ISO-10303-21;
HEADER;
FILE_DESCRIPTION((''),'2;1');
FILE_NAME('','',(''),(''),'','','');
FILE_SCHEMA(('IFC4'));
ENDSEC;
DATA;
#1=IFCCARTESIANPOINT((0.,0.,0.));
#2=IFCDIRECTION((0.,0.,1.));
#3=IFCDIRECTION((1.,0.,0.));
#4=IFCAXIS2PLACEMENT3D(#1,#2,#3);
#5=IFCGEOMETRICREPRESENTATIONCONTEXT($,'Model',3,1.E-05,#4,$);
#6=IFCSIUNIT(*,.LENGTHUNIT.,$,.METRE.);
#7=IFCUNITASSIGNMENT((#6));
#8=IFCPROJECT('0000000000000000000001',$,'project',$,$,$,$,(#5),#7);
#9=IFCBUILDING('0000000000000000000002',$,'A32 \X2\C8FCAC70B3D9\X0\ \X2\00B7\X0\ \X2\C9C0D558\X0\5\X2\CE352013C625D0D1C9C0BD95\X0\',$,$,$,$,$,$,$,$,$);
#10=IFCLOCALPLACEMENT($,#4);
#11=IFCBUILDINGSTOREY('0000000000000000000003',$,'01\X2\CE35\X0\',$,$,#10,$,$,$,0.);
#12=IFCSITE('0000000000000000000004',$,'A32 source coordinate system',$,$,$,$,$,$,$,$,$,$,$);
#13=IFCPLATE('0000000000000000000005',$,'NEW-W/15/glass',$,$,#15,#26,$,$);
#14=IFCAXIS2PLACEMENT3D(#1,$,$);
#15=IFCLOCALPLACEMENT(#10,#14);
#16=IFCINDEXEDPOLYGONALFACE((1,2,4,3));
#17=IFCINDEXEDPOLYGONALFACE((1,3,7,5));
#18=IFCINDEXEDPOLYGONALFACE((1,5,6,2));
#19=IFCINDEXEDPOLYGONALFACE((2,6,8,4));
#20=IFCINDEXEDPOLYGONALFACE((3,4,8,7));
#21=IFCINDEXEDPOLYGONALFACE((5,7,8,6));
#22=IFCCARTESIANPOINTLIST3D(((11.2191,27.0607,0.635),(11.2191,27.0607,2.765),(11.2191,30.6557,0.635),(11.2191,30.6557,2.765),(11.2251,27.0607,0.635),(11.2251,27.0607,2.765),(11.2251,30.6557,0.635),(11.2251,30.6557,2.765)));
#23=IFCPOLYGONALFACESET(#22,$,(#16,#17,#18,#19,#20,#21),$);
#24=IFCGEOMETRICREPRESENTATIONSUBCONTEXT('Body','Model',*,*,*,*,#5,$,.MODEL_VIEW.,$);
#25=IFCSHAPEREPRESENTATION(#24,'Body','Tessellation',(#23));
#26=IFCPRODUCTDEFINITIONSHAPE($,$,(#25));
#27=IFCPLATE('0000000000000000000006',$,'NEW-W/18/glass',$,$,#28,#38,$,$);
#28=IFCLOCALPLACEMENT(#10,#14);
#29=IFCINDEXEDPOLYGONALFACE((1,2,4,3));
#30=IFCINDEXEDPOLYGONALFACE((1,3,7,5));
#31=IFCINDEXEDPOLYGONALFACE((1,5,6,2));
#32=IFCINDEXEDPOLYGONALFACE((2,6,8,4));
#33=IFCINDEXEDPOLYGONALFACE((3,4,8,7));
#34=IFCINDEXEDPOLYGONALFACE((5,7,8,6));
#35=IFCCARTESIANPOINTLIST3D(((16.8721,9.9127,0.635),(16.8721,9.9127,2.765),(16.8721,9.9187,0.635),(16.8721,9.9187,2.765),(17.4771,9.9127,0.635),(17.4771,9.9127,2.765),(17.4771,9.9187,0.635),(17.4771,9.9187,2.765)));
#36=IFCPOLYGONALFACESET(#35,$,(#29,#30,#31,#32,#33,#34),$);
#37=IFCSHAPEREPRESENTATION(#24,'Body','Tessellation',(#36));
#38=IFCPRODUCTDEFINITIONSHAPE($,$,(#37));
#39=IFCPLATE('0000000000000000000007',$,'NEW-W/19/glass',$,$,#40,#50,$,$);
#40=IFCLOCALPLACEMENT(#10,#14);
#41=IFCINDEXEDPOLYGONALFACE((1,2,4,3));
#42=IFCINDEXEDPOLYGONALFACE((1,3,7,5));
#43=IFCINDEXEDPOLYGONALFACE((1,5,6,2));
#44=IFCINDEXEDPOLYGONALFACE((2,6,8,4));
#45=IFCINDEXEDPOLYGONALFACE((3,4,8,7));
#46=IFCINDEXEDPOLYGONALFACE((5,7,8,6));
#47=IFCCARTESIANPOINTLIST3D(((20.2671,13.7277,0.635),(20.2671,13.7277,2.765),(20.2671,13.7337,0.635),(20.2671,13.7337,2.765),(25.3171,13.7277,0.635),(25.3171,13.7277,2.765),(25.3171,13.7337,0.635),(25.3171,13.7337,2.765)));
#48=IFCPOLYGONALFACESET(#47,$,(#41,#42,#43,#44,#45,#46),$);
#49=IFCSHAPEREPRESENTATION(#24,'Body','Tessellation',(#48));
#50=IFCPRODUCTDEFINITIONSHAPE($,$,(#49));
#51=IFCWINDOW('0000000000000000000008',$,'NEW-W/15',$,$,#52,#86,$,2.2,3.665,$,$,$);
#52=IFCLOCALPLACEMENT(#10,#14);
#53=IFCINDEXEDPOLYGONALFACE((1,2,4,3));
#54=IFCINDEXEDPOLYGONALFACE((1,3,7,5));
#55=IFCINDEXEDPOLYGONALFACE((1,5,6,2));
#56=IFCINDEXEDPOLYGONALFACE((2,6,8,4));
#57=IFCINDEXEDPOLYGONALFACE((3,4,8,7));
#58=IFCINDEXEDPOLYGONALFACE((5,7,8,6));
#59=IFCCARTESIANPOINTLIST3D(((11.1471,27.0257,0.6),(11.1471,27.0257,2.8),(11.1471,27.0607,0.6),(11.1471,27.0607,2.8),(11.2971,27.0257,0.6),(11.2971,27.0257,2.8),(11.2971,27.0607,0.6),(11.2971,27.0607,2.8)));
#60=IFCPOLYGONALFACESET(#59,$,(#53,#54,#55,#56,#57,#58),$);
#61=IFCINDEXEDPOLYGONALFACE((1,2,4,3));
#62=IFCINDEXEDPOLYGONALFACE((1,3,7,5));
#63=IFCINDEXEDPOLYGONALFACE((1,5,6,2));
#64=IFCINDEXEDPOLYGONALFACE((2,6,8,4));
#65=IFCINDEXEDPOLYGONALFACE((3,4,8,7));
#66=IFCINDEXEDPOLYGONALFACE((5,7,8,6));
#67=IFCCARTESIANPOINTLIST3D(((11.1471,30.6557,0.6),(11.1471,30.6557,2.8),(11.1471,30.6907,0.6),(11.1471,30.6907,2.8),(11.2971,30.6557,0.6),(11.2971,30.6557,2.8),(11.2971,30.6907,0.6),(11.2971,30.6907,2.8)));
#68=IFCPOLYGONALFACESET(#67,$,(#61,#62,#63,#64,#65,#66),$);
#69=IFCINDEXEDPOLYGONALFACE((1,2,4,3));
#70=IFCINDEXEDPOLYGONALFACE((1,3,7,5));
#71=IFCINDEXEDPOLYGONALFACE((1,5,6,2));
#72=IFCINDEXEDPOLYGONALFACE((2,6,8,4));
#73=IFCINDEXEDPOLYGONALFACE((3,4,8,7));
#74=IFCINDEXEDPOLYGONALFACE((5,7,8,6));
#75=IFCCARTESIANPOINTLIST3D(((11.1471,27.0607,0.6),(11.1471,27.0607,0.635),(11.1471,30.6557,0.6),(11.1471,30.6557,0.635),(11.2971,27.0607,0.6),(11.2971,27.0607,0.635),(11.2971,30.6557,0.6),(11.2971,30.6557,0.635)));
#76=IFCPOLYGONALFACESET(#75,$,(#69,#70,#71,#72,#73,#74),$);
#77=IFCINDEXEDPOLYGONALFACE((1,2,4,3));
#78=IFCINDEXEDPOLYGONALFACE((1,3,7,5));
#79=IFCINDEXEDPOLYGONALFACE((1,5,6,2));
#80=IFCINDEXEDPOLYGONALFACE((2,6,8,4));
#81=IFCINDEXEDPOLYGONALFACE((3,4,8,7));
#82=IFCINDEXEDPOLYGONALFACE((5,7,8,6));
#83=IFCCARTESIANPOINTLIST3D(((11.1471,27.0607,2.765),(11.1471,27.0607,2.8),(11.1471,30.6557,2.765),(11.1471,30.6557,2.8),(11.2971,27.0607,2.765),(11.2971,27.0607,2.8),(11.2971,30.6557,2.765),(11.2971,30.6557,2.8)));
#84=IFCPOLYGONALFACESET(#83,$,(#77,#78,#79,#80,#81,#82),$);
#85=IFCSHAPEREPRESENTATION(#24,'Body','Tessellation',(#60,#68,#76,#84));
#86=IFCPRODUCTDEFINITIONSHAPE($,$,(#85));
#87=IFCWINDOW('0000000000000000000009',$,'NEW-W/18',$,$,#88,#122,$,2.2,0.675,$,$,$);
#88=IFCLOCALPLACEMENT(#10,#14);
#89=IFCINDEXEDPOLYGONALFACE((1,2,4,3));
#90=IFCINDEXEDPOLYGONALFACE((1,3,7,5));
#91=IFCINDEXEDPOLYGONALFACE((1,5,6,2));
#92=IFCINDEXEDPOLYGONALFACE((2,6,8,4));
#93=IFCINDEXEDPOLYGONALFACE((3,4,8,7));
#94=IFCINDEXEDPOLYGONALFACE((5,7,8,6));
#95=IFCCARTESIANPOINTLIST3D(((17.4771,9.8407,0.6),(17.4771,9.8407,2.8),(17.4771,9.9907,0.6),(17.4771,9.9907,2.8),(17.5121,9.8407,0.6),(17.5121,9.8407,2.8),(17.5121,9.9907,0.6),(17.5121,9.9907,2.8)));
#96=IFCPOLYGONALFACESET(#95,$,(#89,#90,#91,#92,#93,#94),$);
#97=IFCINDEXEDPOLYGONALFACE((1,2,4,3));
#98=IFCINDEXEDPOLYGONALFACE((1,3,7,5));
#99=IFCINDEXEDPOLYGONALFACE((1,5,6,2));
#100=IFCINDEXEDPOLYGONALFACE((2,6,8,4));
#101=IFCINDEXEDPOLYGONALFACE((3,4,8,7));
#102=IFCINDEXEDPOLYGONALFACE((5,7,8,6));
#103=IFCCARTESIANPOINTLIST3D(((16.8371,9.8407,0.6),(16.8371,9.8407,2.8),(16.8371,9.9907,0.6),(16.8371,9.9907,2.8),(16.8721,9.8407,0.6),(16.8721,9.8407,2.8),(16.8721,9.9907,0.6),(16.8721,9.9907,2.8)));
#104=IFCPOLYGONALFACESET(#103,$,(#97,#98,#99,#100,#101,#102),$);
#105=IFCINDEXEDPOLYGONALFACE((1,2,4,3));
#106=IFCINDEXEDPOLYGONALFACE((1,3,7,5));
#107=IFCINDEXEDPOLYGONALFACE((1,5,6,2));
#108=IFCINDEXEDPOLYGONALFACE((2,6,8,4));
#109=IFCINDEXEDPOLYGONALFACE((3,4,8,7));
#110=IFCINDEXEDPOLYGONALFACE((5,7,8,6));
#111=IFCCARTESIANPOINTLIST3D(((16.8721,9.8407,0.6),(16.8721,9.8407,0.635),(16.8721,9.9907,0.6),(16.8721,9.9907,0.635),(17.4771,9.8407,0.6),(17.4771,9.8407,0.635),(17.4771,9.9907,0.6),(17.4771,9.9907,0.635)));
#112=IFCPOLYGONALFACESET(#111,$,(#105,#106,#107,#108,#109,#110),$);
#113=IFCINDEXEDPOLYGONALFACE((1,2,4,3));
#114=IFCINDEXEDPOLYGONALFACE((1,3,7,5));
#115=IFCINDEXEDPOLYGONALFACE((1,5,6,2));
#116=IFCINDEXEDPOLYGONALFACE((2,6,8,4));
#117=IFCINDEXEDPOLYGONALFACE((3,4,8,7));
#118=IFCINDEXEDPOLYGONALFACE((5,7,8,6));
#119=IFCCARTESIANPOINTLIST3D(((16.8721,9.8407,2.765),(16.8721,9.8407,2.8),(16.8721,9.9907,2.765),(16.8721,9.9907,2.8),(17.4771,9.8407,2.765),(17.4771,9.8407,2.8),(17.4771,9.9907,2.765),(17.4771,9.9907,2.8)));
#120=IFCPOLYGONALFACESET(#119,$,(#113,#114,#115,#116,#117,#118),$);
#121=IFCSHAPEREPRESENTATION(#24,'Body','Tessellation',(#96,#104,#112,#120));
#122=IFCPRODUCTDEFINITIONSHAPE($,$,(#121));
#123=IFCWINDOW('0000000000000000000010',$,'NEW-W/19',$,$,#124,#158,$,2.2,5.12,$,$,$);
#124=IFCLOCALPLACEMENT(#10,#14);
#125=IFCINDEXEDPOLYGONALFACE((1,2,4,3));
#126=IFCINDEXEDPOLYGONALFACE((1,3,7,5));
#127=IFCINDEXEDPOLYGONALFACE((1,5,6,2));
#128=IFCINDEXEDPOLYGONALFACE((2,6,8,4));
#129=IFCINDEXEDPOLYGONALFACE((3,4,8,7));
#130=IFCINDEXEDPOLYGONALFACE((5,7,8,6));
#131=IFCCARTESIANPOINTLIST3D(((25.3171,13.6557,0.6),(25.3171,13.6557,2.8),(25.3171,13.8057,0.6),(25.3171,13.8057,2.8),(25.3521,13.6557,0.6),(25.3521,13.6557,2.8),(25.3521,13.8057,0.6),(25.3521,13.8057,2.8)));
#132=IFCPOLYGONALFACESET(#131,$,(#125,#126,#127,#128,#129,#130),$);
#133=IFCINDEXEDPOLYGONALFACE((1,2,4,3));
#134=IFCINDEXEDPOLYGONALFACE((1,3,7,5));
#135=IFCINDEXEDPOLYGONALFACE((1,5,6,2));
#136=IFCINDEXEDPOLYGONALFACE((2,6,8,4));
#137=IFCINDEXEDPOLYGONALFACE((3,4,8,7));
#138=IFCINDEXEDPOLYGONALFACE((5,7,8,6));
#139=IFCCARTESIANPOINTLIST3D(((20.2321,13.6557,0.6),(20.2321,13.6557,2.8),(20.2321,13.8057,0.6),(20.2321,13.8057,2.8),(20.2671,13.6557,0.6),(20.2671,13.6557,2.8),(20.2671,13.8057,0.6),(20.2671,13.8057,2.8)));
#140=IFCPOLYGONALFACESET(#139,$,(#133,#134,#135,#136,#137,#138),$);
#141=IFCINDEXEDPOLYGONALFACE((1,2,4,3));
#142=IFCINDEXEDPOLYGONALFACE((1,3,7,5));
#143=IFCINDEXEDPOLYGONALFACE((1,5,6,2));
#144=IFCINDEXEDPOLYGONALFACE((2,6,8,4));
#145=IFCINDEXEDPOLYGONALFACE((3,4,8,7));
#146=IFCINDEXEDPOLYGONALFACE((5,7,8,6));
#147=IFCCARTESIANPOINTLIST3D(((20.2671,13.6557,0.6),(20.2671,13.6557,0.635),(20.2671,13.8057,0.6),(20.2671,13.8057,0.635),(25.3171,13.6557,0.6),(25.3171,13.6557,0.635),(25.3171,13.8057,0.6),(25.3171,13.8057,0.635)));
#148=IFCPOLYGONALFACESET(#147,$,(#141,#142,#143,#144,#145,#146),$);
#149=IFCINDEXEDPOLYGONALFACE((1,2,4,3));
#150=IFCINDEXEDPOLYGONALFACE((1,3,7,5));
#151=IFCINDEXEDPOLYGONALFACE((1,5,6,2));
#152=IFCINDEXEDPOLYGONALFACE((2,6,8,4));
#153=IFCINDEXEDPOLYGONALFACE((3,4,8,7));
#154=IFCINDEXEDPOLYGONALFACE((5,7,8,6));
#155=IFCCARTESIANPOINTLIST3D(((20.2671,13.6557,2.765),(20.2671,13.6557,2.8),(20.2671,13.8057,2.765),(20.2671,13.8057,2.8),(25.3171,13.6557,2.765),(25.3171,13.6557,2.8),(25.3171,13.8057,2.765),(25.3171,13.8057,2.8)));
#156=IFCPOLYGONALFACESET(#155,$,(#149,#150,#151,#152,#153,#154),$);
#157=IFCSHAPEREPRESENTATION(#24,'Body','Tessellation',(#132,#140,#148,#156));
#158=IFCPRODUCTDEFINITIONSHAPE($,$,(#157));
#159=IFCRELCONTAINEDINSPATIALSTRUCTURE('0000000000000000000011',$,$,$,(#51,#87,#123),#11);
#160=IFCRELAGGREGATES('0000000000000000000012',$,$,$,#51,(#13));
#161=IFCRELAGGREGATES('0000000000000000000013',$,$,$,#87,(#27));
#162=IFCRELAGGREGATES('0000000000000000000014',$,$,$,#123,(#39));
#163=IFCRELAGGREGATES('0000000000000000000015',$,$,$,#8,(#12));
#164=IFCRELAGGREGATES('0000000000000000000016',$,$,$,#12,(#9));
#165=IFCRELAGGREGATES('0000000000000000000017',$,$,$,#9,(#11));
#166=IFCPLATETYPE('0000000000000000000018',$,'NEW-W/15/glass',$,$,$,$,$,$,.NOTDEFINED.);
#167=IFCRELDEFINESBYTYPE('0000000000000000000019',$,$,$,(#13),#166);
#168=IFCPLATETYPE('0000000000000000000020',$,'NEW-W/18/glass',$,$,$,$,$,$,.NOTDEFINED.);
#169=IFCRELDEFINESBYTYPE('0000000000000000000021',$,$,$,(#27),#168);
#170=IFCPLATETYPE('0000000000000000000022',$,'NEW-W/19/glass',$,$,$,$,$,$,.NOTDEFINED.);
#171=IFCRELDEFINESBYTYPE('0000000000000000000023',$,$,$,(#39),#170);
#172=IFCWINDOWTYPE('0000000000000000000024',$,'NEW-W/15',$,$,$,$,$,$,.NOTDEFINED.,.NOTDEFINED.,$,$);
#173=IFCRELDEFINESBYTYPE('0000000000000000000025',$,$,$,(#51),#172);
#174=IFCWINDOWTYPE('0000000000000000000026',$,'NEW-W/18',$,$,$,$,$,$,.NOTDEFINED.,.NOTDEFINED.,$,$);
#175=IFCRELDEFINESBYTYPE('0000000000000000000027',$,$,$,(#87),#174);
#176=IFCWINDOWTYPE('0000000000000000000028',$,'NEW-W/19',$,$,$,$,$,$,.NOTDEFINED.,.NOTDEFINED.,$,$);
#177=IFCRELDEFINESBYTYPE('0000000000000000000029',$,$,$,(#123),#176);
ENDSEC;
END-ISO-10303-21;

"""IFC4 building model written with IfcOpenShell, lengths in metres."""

from ifc_helpers import new_model, si_unit, frame, origin, origin_with_axes, place, context, subcontext, project, spatial, polyline, outline, extrude, source, transform, mapped, type_object, type_shapes, element, aggregate, save


model = new_model("IFC4")

# Units and contexts
model_context = context("Model", 3, precision=1e-05, world=origin_with_axes())
body_context = subcontext(model_context, "Body", "Model", "MODEL_VIEW")
ifc_project = project(units=[si_unit("LENGTHUNIT", "METRE")], contexts=[model_context])

# Plates
plate_type_1 = type_object("IfcPlateType", Name="NEW-W/15/glass", PredefinedType="NOTDEFINED")
shared_shape_1 = source(origin(), body_context, "Body", "SweptSolid", [
    extrude(outline(polyline([(11.2251, 27.0607), (11.2191, 27.0607), (11.2191, 30.6557), (11.2251, 30.6557), (11.2251, 27.0607)])), frame((0.0, 0.0, 0.635)), (0.0, 0.0, 1.0), 2.13),
])
type_shapes(plate_type_1, [shared_shape_1])
storey_placement = place(None, origin_with_axes())
window_1_placement = place(storey_placement, origin_with_axes())
plate_1_placement = place(window_1_placement, origin_with_axes())
plate_1 = element("IfcPlate", 1, at=plate_1_placement, type_object=plate_type_1, Name="NEW-W/15/glass", context=body_context, shape_type="MappedRepresentation", body=[
    mapped(shared_shape_1, transform((0.0, 0.0, 0.0), scale=1.0)),
])
plate_type_2 = type_object("IfcPlateType", Name="NEW-W/18/glass", PredefinedType="NOTDEFINED")
shared_shape_2 = source(origin(), body_context, "Body", "SweptSolid", [
    extrude(outline(polyline([(17.4771, 9.9127), (16.8721, 9.9127), (16.8721, 9.9187), (17.4771, 9.9187), (17.4771, 9.9127)])), frame((0.0, 0.0, 0.635)), (0.0, 0.0, 1.0), 2.13),
])
type_shapes(plate_type_2, [shared_shape_2])
window_2_placement = place(storey_placement, origin_with_axes())
plate_2_placement = place(window_2_placement, origin_with_axes())
plate_2 = element("IfcPlate", 2, at=plate_2_placement, type_object=plate_type_2, Name="NEW-W/18/glass", context=body_context, shape_type="MappedRepresentation", body=[
    mapped(shared_shape_2, transform((0.0, 0.0, 0.0), scale=1.0)),
])
plate_type_3 = type_object("IfcPlateType", Name="NEW-W/19/glass", PredefinedType="NOTDEFINED")
shared_shape_3 = source(origin(), body_context, "Body", "SweptSolid", [
    extrude(outline(polyline([(25.3171, 13.7277), (20.2671, 13.7277), (20.2671, 13.7337), (25.3171, 13.7337), (25.3171, 13.7277)])), frame((0.0, 0.0, 0.635)), (0.0, 0.0, 1.0), 2.13),
])
type_shapes(plate_type_3, [shared_shape_3])
window_3_placement = place(storey_placement, origin_with_axes())
plate_3_placement = place(window_3_placement, origin_with_axes())
plate_3 = element("IfcPlate", 3, at=plate_3_placement, type_object=plate_type_3, Name="NEW-W/19/glass", context=body_context, shape_type="MappedRepresentation", body=[
    mapped(shared_shape_3, transform((0.0, 0.0, 0.0), scale=1.0)),
])

# Site, building, storey
site = spatial("IfcSite", under=ifc_project, Name="A32 source coordinate system")
building = spatial("IfcBuilding", under=site, Name="A32 주거동 · 지하5층–옥탑지붕")
storey = spatial("IfcBuildingStorey", under=building, at=storey_placement, Name="01층", Elevation=0.0)

# Windows
window_type_1 = type_object("IfcWindowType", Name="NEW-W/15", PartitioningType="NOTDEFINED", PredefinedType="NOTDEFINED")
shared_shape_4 = source(origin(), body_context, "Body", "SweptSolid", [
    extrude(outline(polyline([(11.1471, 27.0257), (11.1471, 27.0607), (11.2971, 27.0607), (11.2971, 27.0257), (11.1471, 27.0257)])), frame((0.0, 0.0, 0.6)), (0.0, 0.0, 1.0), 2.2),
    extrude(outline(polyline([(11.1471, 30.6557), (11.1471, 30.6907), (11.2971, 30.6907), (11.2971, 30.6557), (11.1471, 30.6557)])), frame((0.0, 0.0, 0.6)), (0.0, 0.0, 1.0), 2.2),
    extrude(outline(polyline([(11.2971, 27.0607), (11.2971, 30.6557), (11.1471, 30.6557), (11.1471, 27.0607), (11.2971, 27.0607)])), frame((0.0, 0.0, 0.6)), (0.0, 0.0, 1.0), 0.035),
    extrude(outline(polyline([(11.2971, 27.0607), (11.2971, 30.6557), (11.1471, 30.6557), (11.1471, 27.0607), (11.2971, 27.0607)])), frame((0.0, 0.0, 2.765)), (0.0, 0.0, 1.0), 0.035),
])
type_shapes(window_type_1, [shared_shape_4])
window_1 = element("IfcWindow", 4, at=window_1_placement, inside=storey, type_object=window_type_1, Name="NEW-W/15", OverallHeight=2.2, OverallWidth=3.665, context=body_context, shape_type="MappedRepresentation", body=[
    mapped(shared_shape_4, transform((0.0, 0.0, 0.0), scale=1.0)),
])
aggregate(window_1, [plate_1])
window_type_2 = type_object("IfcWindowType", Name="NEW-W/18", PartitioningType="NOTDEFINED", PredefinedType="NOTDEFINED")
shared_shape_5 = source(origin(), body_context, "Body", "SweptSolid", [
    extrude(outline(polyline([(17.4771, 9.8407), (17.4771, 9.9907), (17.5121, 9.9907), (17.5121, 9.8407), (17.4771, 9.8407)])), frame((0.0, 0.0, 0.6)), (0.0, 0.0, 1.0), 2.2),
    extrude(outline(polyline([(16.8371, 9.8407), (16.8371, 9.9907), (16.8721, 9.9907), (16.8721, 9.8407), (16.8371, 9.8407)])), frame((0.0, 0.0, 0.6)), (0.0, 0.0, 1.0), 2.2),
    extrude(outline(polyline([(17.4771, 9.8407), (17.4771, 9.9907), (16.8721, 9.9907), (16.8721, 9.8407), (17.4771, 9.8407)])), frame((0.0, 0.0, 0.6)), (0.0, 0.0, 1.0), 0.035),
    extrude(outline(polyline([(17.4771, 9.8407), (17.4771, 9.9907), (16.8721, 9.9907), (16.8721, 9.8407), (17.4771, 9.8407)])), frame((0.0, 0.0, 2.765)), (0.0, 0.0, 1.0), 0.035),
])
type_shapes(window_type_2, [shared_shape_5])
window_2 = element("IfcWindow", 5, at=window_2_placement, inside=storey, type_object=window_type_2, Name="NEW-W/18", OverallHeight=2.2, OverallWidth=0.675, context=body_context, shape_type="MappedRepresentation", body=[
    mapped(shared_shape_5, transform((0.0, 0.0, 0.0), scale=1.0)),
])
aggregate(window_2, [plate_2])
window_type_3 = type_object("IfcWindowType", Name="NEW-W/19", PartitioningType="NOTDEFINED", PredefinedType="NOTDEFINED")
shared_shape_6 = source(origin(), body_context, "Body", "SweptSolid", [
    extrude(outline(polyline([(25.3171, 13.6557), (25.3171, 13.8057), (25.3521, 13.8057), (25.3521, 13.6557), (25.3171, 13.6557)])), frame((0.0, 0.0, 0.6)), (0.0, 0.0, 1.0), 2.2),
    extrude(outline(polyline([(20.2321, 13.6557), (20.2321, 13.8057), (20.2671, 13.8057), (20.2671, 13.6557), (20.2321, 13.6557)])), frame((0.0, 0.0, 0.6)), (0.0, 0.0, 1.0), 2.2),
    extrude(outline(polyline([(25.3171, 13.6557), (25.3171, 13.8057), (20.2671, 13.8057), (20.2671, 13.6557), (25.3171, 13.6557)])), frame((0.0, 0.0, 0.6)), (0.0, 0.0, 1.0), 0.035),
    extrude(outline(polyline([(25.3171, 13.6557), (25.3171, 13.8057), (20.2671, 13.8057), (20.2671, 13.6557), (25.3171, 13.6557)])), frame((0.0, 0.0, 2.765)), (0.0, 0.0, 1.0), 0.035),
])
type_shapes(window_type_3, [shared_shape_6])
window_3 = element("IfcWindow", 6, at=window_3_placement, inside=storey, type_object=window_type_3, Name="NEW-W/19", OverallHeight=2.2, OverallWidth=5.12, context=body_context, shape_type="MappedRepresentation", body=[
    mapped(shared_shape_6, transform((0.0, 0.0, 0.0), scale=1.0)),
])
aggregate(window_3, [plate_3])

save(model, "model.ifc")
